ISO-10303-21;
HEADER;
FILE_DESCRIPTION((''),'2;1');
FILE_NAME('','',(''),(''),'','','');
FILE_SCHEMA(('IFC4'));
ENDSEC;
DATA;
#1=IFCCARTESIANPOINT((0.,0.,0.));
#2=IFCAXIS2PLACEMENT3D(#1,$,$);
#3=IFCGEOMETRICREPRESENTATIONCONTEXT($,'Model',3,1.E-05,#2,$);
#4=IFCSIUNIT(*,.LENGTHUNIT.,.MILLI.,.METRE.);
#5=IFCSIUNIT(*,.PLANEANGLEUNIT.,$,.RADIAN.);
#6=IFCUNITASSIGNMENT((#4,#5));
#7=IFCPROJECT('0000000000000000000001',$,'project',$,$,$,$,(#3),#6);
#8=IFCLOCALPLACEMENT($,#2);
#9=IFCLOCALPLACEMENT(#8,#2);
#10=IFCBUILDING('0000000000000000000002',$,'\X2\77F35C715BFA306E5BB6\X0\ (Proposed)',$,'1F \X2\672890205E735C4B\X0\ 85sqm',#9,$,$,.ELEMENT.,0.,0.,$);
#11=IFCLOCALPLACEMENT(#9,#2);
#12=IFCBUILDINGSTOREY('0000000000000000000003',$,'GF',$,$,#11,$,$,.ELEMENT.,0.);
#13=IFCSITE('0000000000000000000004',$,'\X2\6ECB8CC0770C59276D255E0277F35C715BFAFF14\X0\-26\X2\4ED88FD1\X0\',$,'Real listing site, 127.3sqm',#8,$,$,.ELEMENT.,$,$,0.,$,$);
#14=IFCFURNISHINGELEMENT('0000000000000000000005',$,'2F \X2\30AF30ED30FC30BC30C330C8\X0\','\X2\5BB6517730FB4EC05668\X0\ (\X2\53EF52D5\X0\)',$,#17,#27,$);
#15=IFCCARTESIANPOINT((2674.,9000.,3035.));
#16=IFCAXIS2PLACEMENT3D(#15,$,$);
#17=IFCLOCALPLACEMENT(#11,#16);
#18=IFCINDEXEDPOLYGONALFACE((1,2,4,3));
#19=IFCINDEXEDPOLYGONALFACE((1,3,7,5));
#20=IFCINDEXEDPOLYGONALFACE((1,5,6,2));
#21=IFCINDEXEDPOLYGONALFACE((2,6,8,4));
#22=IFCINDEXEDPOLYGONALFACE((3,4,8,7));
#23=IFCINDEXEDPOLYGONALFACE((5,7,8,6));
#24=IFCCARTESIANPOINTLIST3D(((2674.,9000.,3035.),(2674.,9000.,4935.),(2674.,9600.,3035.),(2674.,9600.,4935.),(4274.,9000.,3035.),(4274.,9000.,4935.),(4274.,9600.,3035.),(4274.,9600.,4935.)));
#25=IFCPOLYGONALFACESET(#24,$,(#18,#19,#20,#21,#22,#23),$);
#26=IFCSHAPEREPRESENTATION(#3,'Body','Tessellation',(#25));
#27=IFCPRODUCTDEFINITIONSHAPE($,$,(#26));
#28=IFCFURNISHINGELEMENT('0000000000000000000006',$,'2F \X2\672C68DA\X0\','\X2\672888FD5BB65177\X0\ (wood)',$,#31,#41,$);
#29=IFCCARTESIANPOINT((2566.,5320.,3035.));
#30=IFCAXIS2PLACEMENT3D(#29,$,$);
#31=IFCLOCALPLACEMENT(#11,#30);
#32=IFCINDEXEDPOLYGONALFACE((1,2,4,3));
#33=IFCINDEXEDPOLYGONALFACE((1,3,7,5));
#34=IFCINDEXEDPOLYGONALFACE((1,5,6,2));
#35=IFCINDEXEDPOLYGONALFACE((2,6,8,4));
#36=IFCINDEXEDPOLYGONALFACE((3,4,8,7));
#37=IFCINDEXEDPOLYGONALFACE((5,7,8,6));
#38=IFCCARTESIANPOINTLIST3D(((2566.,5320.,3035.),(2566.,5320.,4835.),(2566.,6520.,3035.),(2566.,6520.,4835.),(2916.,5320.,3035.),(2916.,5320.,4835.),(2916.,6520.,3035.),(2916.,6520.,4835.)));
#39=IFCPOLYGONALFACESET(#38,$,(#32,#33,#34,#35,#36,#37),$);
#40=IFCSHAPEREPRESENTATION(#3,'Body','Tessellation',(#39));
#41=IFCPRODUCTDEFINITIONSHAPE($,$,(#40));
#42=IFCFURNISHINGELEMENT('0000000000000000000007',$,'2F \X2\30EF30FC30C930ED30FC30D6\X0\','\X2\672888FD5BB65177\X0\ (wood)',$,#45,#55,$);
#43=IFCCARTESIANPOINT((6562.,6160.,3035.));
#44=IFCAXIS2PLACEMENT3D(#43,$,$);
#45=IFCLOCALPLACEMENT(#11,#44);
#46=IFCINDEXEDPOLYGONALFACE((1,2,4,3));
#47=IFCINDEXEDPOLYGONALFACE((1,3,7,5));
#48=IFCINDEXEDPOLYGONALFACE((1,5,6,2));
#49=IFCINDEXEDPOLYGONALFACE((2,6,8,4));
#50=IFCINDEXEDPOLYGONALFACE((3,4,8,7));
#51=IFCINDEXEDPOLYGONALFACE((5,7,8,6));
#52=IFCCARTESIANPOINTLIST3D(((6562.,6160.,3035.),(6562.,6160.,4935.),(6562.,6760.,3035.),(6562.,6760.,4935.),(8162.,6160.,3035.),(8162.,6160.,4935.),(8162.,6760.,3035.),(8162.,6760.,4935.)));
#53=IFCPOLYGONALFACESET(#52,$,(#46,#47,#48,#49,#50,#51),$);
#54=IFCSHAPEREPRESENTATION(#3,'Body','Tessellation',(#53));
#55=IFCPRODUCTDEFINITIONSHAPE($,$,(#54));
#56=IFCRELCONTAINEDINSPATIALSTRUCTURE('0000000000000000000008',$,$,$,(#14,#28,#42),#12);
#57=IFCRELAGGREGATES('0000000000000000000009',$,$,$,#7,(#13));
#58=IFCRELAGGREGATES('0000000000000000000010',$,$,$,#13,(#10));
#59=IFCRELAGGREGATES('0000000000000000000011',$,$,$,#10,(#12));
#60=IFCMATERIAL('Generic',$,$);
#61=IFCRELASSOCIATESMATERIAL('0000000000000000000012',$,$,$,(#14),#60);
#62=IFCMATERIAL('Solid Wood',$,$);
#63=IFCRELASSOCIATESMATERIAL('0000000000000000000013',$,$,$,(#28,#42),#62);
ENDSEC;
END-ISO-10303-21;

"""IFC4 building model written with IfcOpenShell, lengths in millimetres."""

from ifc_helpers import new_model, si_unit, frame, frame_2d, origin, place, context, project, spatial, rectangle, extrude, material, element, save


model = new_model("IFC4")

# Units and contexts
model_context = context("Model", 3, precision=1e-05, world=origin())
ifc_project = project(units=[si_unit("LENGTHUNIT", "METRE", prefix="MILLI"), si_unit("PLANEANGLEUNIT", "RADIAN")], contexts=[model_context])

# Site, building, storey
site_placement = place(None, origin())
site = spatial("IfcSite", under=ifc_project, at=site_placement, Name="滋賀県大津市石山寺４-26付近", ObjectType="Real listing site, 127.3sqm", CompositionType="ELEMENT", RefElevation=0.0)
building_placement = place(site_placement, origin())
building = spatial("IfcBuilding", under=site, at=building_placement, Name="石山寺の家 (Proposed)", ObjectType="1F 木造平屋 85sqm", CompositionType="ELEMENT", ElevationOfRefHeight=0.0, ElevationOfTerrain=0.0)
storey_placement = place(building_placement, origin())
storey = spatial("IfcBuildingStorey", under=building, at=storey_placement, Name="GF", CompositionType="ELEMENT", Elevation=0.0)

# Shared definitions
ifc_material_1 = material(Name="Solid Wood")

# Shared definitions
ifc_material_2 = material(Name="Generic")

# Furnishing elements
furnishing_1_placement = place(storey_placement, frame((2674.0, 9000.0, 3035.0)))
element("IfcFurnishingElement", 1, at=furnishing_1_placement, inside=storey, material=ifc_material_2, Name="2F クローゼット", Description="家具・什器 (可動)", context=model_context, shape_type="SweptSolid", body=[
    extrude(rectangle(XDim=1600.0, YDim=600.0, at=frame_2d((800.0, 300.0))), frame((2674.0, 9000.0, 3035.0)), (0.0, 0.0, 1.0), 1900.0),
])
furnishing_2_placement = place(storey_placement, frame((2566.0, 5320.0, 3035.0)))
element("IfcFurnishingElement", 2, at=furnishing_2_placement, inside=storey, material=ifc_material_1, Name="2F 本棚", Description="木製家具 (wood)", context=model_context, shape_type="SweptSolid", body=[
    extrude(rectangle(XDim=350.0, YDim=1200.0, at=frame_2d((175.0, 600.0))), frame((2566.0, 5320.0, 3035.0)), (0.0, 0.0, 1.0), 1800.0),
])
furnishing_3_placement = place(storey_placement, frame((6562.0, 6160.0, 3035.0)))
element("IfcFurnishingElement", 3, at=furnishing_3_placement, inside=storey, material=ifc_material_1, Name="2F ワードローブ", Description="木製家具 (wood)", context=model_context, shape_type="SweptSolid", body=[
    extrude(rectangle(XDim=1600.0, YDim=600.0, at=frame_2d((800.0, 300.0))), frame((6562.0, 6160.0, 3035.0)), (0.0, 0.0, 1.0), 1900.0),
])

save(model, "model.ifc")
